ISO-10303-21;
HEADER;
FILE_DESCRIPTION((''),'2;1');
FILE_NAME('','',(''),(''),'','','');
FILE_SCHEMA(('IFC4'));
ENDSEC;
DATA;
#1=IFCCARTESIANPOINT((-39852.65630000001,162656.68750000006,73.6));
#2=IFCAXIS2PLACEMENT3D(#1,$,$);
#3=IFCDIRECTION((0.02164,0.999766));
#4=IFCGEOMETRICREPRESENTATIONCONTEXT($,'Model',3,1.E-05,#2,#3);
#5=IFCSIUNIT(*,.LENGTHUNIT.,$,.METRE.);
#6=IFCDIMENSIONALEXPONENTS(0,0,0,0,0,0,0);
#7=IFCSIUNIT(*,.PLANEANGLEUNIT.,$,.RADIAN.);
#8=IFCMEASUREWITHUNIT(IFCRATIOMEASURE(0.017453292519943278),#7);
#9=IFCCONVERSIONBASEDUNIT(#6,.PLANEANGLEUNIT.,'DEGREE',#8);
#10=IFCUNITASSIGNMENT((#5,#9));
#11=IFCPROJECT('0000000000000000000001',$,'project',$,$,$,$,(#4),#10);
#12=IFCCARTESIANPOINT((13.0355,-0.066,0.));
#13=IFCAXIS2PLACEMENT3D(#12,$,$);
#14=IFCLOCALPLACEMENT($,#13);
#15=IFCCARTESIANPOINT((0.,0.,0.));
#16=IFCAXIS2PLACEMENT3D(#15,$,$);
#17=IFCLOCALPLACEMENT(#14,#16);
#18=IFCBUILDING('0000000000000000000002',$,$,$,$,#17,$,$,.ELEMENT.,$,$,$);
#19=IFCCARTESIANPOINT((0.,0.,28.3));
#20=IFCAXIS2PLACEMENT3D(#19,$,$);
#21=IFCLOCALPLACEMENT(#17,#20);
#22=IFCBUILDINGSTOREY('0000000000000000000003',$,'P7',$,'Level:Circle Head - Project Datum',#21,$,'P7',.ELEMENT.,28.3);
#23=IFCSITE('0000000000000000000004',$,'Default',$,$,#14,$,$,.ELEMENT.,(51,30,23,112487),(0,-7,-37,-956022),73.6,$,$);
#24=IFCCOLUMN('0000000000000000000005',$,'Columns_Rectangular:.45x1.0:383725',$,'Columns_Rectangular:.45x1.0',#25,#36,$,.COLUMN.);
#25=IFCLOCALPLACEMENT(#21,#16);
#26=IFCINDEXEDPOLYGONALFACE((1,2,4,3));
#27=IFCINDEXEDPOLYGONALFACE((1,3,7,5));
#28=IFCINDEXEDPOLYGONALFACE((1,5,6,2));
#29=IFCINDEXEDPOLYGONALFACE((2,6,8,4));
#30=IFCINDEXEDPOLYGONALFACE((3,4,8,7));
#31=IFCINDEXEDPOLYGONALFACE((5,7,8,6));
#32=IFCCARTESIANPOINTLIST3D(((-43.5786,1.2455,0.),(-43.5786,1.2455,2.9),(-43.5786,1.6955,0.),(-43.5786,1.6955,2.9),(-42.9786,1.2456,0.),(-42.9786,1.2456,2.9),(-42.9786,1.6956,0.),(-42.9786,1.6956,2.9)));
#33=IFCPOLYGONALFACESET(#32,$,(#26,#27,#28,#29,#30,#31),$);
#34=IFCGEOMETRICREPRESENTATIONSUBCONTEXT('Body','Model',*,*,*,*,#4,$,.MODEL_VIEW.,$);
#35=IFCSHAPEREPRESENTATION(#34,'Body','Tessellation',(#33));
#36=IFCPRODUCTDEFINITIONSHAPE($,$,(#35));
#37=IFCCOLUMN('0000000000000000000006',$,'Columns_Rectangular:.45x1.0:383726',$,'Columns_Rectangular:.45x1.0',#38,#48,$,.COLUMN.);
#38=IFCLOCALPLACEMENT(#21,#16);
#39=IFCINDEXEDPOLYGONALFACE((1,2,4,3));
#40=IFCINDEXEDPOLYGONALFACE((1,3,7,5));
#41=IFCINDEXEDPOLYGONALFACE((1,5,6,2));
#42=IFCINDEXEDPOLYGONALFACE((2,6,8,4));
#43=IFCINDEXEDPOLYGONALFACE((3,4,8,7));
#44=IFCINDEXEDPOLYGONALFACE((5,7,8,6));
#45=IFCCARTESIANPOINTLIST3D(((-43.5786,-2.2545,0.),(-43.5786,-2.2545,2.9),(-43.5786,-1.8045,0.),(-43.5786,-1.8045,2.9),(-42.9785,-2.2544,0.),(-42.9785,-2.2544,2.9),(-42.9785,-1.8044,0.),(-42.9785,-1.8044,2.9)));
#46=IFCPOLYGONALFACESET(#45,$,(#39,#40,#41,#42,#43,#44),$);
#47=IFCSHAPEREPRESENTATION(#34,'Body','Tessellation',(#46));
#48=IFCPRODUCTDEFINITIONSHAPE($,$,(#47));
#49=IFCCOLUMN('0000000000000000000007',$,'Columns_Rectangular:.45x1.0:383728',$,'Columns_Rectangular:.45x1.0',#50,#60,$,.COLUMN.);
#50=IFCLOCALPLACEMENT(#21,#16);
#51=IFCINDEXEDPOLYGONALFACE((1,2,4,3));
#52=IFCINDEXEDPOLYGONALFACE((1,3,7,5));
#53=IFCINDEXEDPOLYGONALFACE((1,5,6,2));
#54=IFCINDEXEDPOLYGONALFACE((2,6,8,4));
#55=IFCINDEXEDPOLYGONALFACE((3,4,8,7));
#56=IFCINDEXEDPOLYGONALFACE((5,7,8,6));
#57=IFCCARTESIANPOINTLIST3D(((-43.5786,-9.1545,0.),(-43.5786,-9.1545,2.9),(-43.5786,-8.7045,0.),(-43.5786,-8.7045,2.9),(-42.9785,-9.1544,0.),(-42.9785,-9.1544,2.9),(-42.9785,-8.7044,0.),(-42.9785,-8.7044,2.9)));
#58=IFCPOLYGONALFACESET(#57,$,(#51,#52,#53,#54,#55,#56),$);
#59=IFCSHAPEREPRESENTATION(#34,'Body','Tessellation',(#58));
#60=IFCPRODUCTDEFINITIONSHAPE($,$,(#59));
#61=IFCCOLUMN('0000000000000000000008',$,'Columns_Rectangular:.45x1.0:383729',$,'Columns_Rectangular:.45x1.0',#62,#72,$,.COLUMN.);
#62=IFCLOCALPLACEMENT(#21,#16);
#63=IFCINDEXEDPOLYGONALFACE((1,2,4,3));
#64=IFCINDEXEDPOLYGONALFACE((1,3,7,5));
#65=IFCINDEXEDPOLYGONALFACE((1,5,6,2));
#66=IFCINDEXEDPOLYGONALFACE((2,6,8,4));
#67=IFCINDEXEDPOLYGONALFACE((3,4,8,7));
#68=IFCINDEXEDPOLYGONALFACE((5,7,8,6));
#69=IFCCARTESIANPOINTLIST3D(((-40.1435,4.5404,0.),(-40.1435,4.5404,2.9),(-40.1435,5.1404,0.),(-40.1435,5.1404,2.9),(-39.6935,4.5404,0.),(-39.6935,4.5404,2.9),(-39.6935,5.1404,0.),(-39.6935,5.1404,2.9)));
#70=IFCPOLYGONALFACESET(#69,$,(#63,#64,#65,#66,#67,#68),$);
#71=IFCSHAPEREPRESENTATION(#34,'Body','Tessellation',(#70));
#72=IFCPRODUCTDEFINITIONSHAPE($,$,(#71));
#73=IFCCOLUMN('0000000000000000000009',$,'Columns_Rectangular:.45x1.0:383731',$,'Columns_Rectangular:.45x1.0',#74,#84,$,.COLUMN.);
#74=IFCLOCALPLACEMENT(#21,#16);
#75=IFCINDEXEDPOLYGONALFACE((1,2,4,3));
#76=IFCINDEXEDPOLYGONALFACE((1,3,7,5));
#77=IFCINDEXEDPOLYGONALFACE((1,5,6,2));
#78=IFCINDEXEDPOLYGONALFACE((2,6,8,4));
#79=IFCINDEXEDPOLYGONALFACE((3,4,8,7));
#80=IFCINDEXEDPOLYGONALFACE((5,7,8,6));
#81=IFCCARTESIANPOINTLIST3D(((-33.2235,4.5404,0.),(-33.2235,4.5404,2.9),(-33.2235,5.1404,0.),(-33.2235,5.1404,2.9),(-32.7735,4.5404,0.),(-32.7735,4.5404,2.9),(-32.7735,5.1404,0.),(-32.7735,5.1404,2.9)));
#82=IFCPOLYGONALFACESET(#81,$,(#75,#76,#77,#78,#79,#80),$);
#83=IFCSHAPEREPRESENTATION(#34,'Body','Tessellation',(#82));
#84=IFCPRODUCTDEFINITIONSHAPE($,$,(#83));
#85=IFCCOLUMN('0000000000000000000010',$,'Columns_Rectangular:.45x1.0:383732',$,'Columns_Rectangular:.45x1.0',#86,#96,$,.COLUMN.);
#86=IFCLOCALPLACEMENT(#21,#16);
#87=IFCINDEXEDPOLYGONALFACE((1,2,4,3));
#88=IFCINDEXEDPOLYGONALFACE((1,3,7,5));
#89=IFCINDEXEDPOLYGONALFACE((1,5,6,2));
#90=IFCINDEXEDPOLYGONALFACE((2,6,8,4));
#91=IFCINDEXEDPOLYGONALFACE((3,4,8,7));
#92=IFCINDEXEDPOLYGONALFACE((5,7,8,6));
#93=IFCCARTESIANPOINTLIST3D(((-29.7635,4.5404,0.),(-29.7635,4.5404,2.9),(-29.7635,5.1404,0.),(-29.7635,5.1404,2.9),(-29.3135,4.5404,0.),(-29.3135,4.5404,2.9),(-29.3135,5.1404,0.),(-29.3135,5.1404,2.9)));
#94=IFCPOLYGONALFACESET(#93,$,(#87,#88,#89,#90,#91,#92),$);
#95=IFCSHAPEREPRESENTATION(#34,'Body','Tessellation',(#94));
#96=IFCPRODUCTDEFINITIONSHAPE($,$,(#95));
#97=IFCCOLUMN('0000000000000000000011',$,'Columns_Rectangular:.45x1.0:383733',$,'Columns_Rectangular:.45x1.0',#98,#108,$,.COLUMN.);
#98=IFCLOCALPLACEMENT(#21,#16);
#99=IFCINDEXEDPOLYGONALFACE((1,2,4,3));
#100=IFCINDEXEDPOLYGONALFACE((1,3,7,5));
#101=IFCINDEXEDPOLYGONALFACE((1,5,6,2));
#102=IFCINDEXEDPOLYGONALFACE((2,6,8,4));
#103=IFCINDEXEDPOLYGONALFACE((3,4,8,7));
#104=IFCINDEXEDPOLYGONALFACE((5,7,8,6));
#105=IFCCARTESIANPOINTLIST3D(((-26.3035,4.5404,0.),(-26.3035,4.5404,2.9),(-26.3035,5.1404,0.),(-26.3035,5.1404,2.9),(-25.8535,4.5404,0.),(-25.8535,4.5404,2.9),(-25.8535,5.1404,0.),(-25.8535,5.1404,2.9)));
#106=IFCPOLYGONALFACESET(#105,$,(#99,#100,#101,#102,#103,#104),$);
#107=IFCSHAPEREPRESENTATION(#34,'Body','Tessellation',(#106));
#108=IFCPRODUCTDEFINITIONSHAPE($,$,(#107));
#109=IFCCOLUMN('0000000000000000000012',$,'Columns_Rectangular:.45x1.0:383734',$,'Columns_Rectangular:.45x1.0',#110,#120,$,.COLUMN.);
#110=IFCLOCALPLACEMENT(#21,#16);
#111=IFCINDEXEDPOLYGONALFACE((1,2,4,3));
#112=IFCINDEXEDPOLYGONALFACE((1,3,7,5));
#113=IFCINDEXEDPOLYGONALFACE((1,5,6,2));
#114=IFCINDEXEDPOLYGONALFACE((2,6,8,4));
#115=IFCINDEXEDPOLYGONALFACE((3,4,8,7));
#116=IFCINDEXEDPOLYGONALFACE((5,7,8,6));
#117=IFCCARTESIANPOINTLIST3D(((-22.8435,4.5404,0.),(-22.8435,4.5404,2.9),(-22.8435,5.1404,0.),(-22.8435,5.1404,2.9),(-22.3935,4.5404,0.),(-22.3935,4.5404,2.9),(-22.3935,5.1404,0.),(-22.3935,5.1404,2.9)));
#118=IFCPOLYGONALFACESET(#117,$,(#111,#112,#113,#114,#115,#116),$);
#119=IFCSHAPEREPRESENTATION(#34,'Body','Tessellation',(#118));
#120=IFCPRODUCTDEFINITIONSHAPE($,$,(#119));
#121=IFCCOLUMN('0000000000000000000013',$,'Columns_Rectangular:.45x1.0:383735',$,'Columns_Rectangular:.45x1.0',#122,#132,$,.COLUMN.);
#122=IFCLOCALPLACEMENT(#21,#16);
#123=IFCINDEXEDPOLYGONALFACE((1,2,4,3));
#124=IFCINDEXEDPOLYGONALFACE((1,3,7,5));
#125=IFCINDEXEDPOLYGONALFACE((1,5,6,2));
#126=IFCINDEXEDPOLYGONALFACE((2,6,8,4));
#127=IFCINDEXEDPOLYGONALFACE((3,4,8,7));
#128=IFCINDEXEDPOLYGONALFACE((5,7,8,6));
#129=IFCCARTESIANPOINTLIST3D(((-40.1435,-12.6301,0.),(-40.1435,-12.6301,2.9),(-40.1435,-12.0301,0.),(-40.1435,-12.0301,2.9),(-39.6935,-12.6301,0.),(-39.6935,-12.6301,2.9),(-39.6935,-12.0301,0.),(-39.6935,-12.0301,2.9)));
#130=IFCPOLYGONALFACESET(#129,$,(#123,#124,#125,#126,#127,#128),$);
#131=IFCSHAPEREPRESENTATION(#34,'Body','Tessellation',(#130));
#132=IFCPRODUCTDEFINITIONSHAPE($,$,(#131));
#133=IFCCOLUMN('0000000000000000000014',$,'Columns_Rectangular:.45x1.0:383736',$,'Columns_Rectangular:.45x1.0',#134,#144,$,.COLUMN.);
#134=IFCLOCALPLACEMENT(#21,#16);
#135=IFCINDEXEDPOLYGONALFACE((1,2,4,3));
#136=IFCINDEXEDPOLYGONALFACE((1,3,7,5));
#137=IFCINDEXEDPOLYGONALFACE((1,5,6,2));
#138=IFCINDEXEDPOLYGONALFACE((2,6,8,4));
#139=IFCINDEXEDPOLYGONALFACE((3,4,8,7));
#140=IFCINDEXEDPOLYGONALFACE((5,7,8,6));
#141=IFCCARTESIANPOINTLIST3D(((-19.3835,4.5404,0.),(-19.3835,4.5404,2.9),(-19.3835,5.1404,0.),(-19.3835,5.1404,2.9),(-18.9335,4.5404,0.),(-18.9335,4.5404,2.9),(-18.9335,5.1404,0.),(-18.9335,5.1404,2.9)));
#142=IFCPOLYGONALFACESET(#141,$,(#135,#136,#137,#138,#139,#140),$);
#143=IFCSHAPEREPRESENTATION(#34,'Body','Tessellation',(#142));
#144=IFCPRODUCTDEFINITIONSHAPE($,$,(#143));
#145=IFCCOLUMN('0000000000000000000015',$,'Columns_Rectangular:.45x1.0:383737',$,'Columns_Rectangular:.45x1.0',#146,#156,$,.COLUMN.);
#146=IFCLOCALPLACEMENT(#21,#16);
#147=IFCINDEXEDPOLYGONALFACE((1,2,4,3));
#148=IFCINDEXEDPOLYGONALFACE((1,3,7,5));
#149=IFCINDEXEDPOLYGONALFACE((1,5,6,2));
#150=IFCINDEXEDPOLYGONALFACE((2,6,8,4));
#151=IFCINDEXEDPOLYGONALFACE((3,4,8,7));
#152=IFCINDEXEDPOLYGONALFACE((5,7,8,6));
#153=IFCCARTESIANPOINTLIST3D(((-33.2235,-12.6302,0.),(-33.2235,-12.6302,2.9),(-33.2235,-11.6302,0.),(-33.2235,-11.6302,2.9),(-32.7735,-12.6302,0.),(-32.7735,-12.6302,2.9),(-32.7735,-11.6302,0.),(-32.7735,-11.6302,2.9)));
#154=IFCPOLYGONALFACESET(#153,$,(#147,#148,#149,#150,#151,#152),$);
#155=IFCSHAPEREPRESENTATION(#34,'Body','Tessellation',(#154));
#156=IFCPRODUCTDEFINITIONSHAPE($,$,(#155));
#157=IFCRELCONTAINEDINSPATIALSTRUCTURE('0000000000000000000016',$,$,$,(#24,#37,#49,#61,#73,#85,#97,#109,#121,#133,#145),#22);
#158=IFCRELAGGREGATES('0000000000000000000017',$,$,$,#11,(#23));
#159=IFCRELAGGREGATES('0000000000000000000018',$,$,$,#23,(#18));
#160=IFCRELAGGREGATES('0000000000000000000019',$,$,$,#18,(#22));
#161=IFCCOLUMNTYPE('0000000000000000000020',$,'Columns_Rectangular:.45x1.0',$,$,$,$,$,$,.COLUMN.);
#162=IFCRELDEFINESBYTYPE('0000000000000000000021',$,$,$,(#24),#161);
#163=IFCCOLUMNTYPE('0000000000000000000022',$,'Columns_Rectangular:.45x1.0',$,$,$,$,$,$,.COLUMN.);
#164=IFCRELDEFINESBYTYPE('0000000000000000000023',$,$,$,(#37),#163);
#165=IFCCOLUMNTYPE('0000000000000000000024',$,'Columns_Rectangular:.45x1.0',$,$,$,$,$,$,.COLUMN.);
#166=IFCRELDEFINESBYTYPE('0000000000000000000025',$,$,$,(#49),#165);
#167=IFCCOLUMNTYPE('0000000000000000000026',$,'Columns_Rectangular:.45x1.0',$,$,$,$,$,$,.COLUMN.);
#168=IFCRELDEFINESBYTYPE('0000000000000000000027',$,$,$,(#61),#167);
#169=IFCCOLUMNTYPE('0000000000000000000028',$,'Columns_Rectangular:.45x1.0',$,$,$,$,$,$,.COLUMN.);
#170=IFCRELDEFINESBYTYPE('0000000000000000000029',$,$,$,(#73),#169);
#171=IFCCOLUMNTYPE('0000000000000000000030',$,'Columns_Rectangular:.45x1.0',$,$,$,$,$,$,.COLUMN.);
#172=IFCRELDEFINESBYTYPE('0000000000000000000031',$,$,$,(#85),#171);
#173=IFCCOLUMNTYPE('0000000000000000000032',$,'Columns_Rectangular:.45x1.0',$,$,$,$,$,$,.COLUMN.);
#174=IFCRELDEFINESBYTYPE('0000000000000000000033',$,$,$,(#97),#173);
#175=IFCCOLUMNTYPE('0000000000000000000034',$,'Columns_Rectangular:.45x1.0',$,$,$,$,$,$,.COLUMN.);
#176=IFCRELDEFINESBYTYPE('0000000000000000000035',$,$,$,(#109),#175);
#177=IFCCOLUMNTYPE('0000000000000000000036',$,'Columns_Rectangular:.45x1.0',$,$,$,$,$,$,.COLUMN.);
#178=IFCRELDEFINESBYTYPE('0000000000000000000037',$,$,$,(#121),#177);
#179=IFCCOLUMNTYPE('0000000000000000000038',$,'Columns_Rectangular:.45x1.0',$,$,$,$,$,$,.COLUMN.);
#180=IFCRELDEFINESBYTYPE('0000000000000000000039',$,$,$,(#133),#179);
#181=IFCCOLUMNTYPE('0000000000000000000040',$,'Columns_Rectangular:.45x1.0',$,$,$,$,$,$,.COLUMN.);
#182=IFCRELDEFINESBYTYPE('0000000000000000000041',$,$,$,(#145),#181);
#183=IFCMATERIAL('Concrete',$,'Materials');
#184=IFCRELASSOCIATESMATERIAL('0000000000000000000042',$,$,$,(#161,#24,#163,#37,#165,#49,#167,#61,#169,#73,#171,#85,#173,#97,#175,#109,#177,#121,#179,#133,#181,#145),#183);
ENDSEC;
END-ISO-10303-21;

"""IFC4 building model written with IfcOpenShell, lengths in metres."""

from ifc_helpers import new_model, entity, si_unit, converted_unit, direction, frame, origin, place, context, subcontext, project, spatial, indexed_curve, outline, extrude, source, transform, mapped, material, type_object, type_shapes, element, save


model = new_model("IFC4")

# Units and contexts
model_context = context("Model", 3, precision=1e-05, world=frame((-39852.65630000001, 162656.68750000006, 73.6)), true_north=direction((0.02164, 0.999766)))
body_context = subcontext(model_context, "Body", "Model", "MODEL_VIEW")
ifc_project = project(units=[si_unit("LENGTHUNIT", "METRE"), converted_unit("PLANEANGLEUNIT", "DEGREE", entity("IfcRatioMeasure", 0.017453292519943278), si_unit("PLANEANGLEUNIT", "RADIAN"), dimensions=[0, 0, 0, 0, 0, 0, 0])], contexts=[model_context])

# Site, building, storey
site_placement = place(None, frame((13.0355, -0.066, 0.0)))
site = spatial("IfcSite", under=ifc_project, at=site_placement, Name="Default", CompositionType="ELEMENT", RefLatitude=(51, 30, 23, 112487), RefLongitude=(0, -7, -37, -956022), RefElevation=73.6)
building_placement = place(site_placement, origin())
building = spatial("IfcBuilding", under=site, at=building_placement, CompositionType="ELEMENT")
storey_placement = place(building_placement, frame((0.0, 0.0, 28.3)))
storey = spatial("IfcBuildingStorey", under=building, at=storey_placement, Name="P7", ObjectType="Level:Circle Head - Project Datum", LongName="P7", CompositionType="ELEMENT", Elevation=28.3)

# Columns
ifc_material = material(Name="Concrete", Category="Materials")
column_type_1 = type_object("IfcColumnType", Name="Columns_Rectangular:.45x1.0", PredefinedType="COLUMN", material=ifc_material)
shared_shape_1 = source(origin(), body_context, "Body", "SweptSolid", [
    extrude(outline(indexed_curve([(-0.3, -0.225), (0.3, -0.225), (0.3, 0.225), (-0.3, 0.225), (-0.3, -0.225)], self_intersect=False)), frame((-43.2786, 1.4706, 28.3), z_axis=(0.0, 0.0, 1.0), x_axis=(-1.0, -0.000005, 0.0)), (0.0, 0.0, 1.0), 2.9),
])
type_shapes(column_type_1, [shared_shape_1])
column_1_placement = place(storey_placement, frame((0.0, 0.0, -28.3)))
element("IfcColumn", 1, at=column_1_placement, inside=storey, type_object=column_type_1, material=ifc_material, Name="Columns_Rectangular:.45x1.0:383725", ObjectType="Columns_Rectangular:.45x1.0", PredefinedType="COLUMN", context=body_context, shape_type="MappedRepresentation", body=[
    mapped(shared_shape_1, transform((0.0, 0.0, 0.0), scale=1.0)),
])
column_type_2 = type_object("IfcColumnType", Name="Columns_Rectangular:.45x1.0", PredefinedType="COLUMN", material=ifc_material)
shared_shape_2 = source(origin(), body_context, "Body", "SweptSolid", [
    extrude(outline(indexed_curve([(-0.3, -0.225), (0.3, -0.225), (0.3, 0.225), (-0.3, 0.225), (-0.3, -0.225)], self_intersect=False)), frame((-43.2785, -2.0294, 28.3), z_axis=(0.0, 0.0, 1.0), x_axis=(-1.0, -0.000005, 0.0)), (0.0, 0.0, 1.0), 2.9),
])
type_shapes(column_type_2, [shared_shape_2])
column_2_placement = place(storey_placement, frame((0.0, 0.0, -28.3)))
element("IfcColumn", 2, at=column_2_placement, inside=storey, type_object=column_type_2, material=ifc_material, Name="Columns_Rectangular:.45x1.0:383726", ObjectType="Columns_Rectangular:.45x1.0", PredefinedType="COLUMN", context=body_context, shape_type="MappedRepresentation", body=[
    mapped(shared_shape_2, transform((0.0, 0.0, 0.0), scale=1.0)),
])
column_type_3 = type_object("IfcColumnType", Name="Columns_Rectangular:.45x1.0", PredefinedType="COLUMN", material=ifc_material)
shared_shape_3 = source(origin(), body_context, "Body", "SweptSolid", [
    extrude(outline(indexed_curve([(-0.3, -0.225), (0.3, -0.225), (0.3, 0.225), (-0.3, 0.225), (-0.3, -0.225)], self_intersect=False)), frame((-43.2785, -8.9294, 28.3), z_axis=(0.0, 0.0, 1.0), x_axis=(-1.0, -0.000005, 0.0)), (0.0, 0.0, 1.0), 2.9),
])
type_shapes(column_type_3, [shared_shape_3])
column_3_placement = place(storey_placement, frame((0.0, 0.0, -28.3)))
element("IfcColumn", 3, at=column_3_placement, inside=storey, type_object=column_type_3, material=ifc_material, Name="Columns_Rectangular:.45x1.0:383728", ObjectType="Columns_Rectangular:.45x1.0", PredefinedType="COLUMN", context=body_context, shape_type="MappedRepresentation", body=[
    mapped(shared_shape_3, transform((0.0, 0.0, 0.0), scale=1.0)),
])
column_type_4 = type_object("IfcColumnType", Name="Columns_Rectangular:.45x1.0", PredefinedType="COLUMN", material=ifc_material)
shared_shape_4 = source(origin(), body_context, "Body", "SweptSolid", [
    extrude(outline(indexed_curve([(-0.3, -0.225), (0.3, -0.225), (0.3, 0.225), (-0.3, 0.225), (-0.3, -0.225)], self_intersect=False)), frame((-39.9185, 4.8404, 28.3), z_axis=(0.0, 0.0, 1.0), x_axis=(0.0, -1.0, 0.0)), (0.0, 0.0, 1.0), 2.9),
])
type_shapes(column_type_4, [shared_shape_4])
column_4_placement = place(storey_placement, frame((0.0, 0.0, -28.3)))
element("IfcColumn", 4, at=column_4_placement, inside=storey, type_object=column_type_4, material=ifc_material, Name="Columns_Rectangular:.45x1.0:383729", ObjectType="Columns_Rectangular:.45x1.0", PredefinedType="COLUMN", context=body_context, shape_type="MappedRepresentation", body=[
    mapped(shared_shape_4, transform((0.0, 0.0, 0.0), scale=1.0)),
])
column_type_5 = type_object("IfcColumnType", Name="Columns_Rectangular:.45x1.0", PredefinedType="COLUMN", material=ifc_material)
shared_shape_5 = source(origin(), body_context, "Body", "SweptSolid", [
    extrude(outline(indexed_curve([(-0.3, -0.225), (0.3, -0.225), (0.3, 0.225), (-0.3, 0.225), (-0.3, -0.225)], self_intersect=False)), frame((-32.9985, 4.8404, 28.3), z_axis=(0.0, 0.0, 1.0), x_axis=(0.0, -1.0, 0.0)), (0.0, 0.0, 1.0), 2.9),
])
type_shapes(column_type_5, [shared_shape_5])
column_5_placement = place(storey_placement, frame((0.0, 0.0, -28.3)))
element("IfcColumn", 5, at=column_5_placement, inside=storey, type_object=column_type_5, material=ifc_material, Name="Columns_Rectangular:.45x1.0:383731", ObjectType="Columns_Rectangular:.45x1.0", PredefinedType="COLUMN", context=body_context, shape_type="MappedRepresentation", body=[
    mapped(shared_shape_5, transform((0.0, 0.0, 0.0), scale=1.0)),
])
column_type_6 = type_object("IfcColumnType", Name="Columns_Rectangular:.45x1.0", PredefinedType="COLUMN", material=ifc_material)
shared_shape_6 = source(origin(), body_context, "Body", "SweptSolid", [
    extrude(outline(indexed_curve([(-0.3, -0.225), (0.3, -0.225), (0.3, 0.225), (-0.3, 0.225), (-0.3, -0.225)], self_intersect=False)), frame((-29.5385, 4.8404, 28.3), z_axis=(0.0, 0.0, 1.0), x_axis=(0.0, -1.0, 0.0)), (0.0, 0.0, 1.0), 2.9),
])
type_shapes(column_type_6, [shared_shape_6])
column_6_placement = place(storey_placement, frame((0.0, 0.0, -28.3)))
element("IfcColumn", 6, at=column_6_placement, inside=storey, type_object=column_type_6, material=ifc_material, Name="Columns_Rectangular:.45x1.0:383732", ObjectType="Columns_Rectangular:.45x1.0", PredefinedType="COLUMN", context=body_context, shape_type="MappedRepresentation", body=[
    mapped(shared_shape_6, transform((0.0, 0.0, 0.0), scale=1.0)),
])
column_type_7 = type_object("IfcColumnType", Name="Columns_Rectangular:.45x1.0", PredefinedType="COLUMN", material=ifc_material)
shared_shape_7 = source(origin(), body_context, "Body", "SweptSolid", [
    extrude(outline(indexed_curve([(-0.3, -0.225), (0.3, -0.225), (0.3, 0.225), (-0.3, 0.225), (-0.3, -0.225)], self_intersect=False)), frame((-26.0785, 4.8404, 28.3), z_axis=(0.0, 0.0, 1.0), x_axis=(0.0, -1.0, 0.0)), (0.0, 0.0, 1.0), 2.9),
])
type_shapes(column_type_7, [shared_shape_7])
column_7_placement = place(storey_placement, frame((0.0, 0.0, -28.3)))
element("IfcColumn", 7, at=column_7_placement, inside=storey, type_object=column_type_7, material=ifc_material, Name="Columns_Rectangular:.45x1.0:383733", ObjectType="Columns_Rectangular:.45x1.0", PredefinedType="COLUMN", context=body_context, shape_type="MappedRepresentation", body=[
    mapped(shared_shape_7, transform((0.0, 0.0, 0.0), scale=1.0)),
])
column_type_8 = type_object("IfcColumnType", Name="Columns_Rectangular:.45x1.0", PredefinedType="COLUMN", material=ifc_material)
shared_shape_8 = source(origin(), body_context, "Body", "SweptSolid", [
    extrude(outline(indexed_curve([(-0.3, -0.225), (0.3, -0.225), (0.3, 0.225), (-0.3, 0.225), (-0.3, -0.225)], self_intersect=False)), frame((-22.6185, 4.8404, 28.3), z_axis=(0.0, 0.0, 1.0), x_axis=(0.0, -1.0, 0.0)), (0.0, 0.0, 1.0), 2.9),
])
type_shapes(column_type_8, [shared_shape_8])
column_8_placement = place(storey_placement, frame((0.0, 0.0, -28.3)))
element("IfcColumn", 8, at=column_8_placement, inside=storey, type_object=column_type_8, material=ifc_material, Name="Columns_Rectangular:.45x1.0:383734", ObjectType="Columns_Rectangular:.45x1.0", PredefinedType="COLUMN", context=body_context, shape_type="MappedRepresentation", body=[
    mapped(shared_shape_8, transform((0.0, 0.0, 0.0), scale=1.0)),
])
column_type_9 = type_object("IfcColumnType", Name="Columns_Rectangular:.45x1.0", PredefinedType="COLUMN", material=ifc_material)
shared_shape_9 = source(origin(), body_context, "Body", "SweptSolid", [
    extrude(outline(indexed_curve([(-0.3, -0.225), (0.3, -0.225), (0.3, 0.225), (-0.3, 0.225), (-0.3, -0.225)], self_intersect=False)), frame((-39.9185, -12.3301, 28.3), z_axis=(0.0, 0.0, 1.0), x_axis=(0.000011, 1.0, 0.0)), (0.0, 0.0, 1.0), 2.9),
])
type_shapes(column_type_9, [shared_shape_9])
column_9_placement = place(storey_placement, frame((0.0, 0.0, -28.3)))
element("IfcColumn", 9, at=column_9_placement, inside=storey, type_object=column_type_9, material=ifc_material, Name="Columns_Rectangular:.45x1.0:383735", ObjectType="Columns_Rectangular:.45x1.0", PredefinedType="COLUMN", context=body_context, shape_type="MappedRepresentation", body=[
    mapped(shared_shape_9, transform((0.0, 0.0, 0.0), scale=1.0)),
])
column_type_10 = type_object("IfcColumnType", Name="Columns_Rectangular:.45x1.0", PredefinedType="COLUMN", material=ifc_material)
shared_shape_10 = source(origin(), body_context, "Body", "SweptSolid", [
    extrude(outline(indexed_curve([(-0.3, -0.225), (0.3, -0.225), (0.3, 0.225), (-0.3, 0.225), (-0.3, -0.225)], self_intersect=False)), frame((-19.1585, 4.8404, 28.3), z_axis=(0.0, 0.0, 1.0), x_axis=(0.0, -1.0, 0.0)), (0.0, 0.0, 1.0), 2.9),
])
type_shapes(column_type_10, [shared_shape_10])
column_10_placement = place(storey_placement, frame((0.0, 0.0, -28.3)))
element("IfcColumn", 10, at=column_10_placement, inside=storey, type_object=column_type_10, material=ifc_material, Name="Columns_Rectangular:.45x1.0:383736", ObjectType="Columns_Rectangular:.45x1.0", PredefinedType="COLUMN", context=body_context, shape_type="MappedRepresentation", body=[
    mapped(shared_shape_10, transform((0.0, 0.0, 0.0), scale=1.0)),
])
column_type_11 = type_object("IfcColumnType", Name="Columns_Rectangular:.45x1.0", PredefinedType="COLUMN", material=ifc_material)
shared_shape_11 = source(origin(), body_context, "Body", "SweptSolid", [
    extrude(outline(indexed_curve([(-0.5, -0.225), (0.5, -0.225), (0.5, 0.225), (-0.5, 0.225), (-0.5, -0.225)], self_intersect=False)), frame((-32.9985, -12.1302, 28.3), z_axis=(0.0, 0.0, 1.0), x_axis=(0.000011, 1.0, 0.0)), (0.0, 0.0, 1.0), 2.9),
])
type_shapes(column_type_11, [shared_shape_11])
column_11_placement = place(storey_placement, frame((0.0, 0.0, -28.3)))
element("IfcColumn", 11, at=column_11_placement, inside=storey, type_object=column_type_11, material=ifc_material, Name="Columns_Rectangular:.45x1.0:383737", ObjectType="Columns_Rectangular:.45x1.0", PredefinedType="COLUMN", context=body_context, shape_type="MappedRepresentation", body=[
    mapped(shared_shape_11, transform((0.0, 0.0, 0.0), scale=1.0)),
])

save(model, "model.ifc")
